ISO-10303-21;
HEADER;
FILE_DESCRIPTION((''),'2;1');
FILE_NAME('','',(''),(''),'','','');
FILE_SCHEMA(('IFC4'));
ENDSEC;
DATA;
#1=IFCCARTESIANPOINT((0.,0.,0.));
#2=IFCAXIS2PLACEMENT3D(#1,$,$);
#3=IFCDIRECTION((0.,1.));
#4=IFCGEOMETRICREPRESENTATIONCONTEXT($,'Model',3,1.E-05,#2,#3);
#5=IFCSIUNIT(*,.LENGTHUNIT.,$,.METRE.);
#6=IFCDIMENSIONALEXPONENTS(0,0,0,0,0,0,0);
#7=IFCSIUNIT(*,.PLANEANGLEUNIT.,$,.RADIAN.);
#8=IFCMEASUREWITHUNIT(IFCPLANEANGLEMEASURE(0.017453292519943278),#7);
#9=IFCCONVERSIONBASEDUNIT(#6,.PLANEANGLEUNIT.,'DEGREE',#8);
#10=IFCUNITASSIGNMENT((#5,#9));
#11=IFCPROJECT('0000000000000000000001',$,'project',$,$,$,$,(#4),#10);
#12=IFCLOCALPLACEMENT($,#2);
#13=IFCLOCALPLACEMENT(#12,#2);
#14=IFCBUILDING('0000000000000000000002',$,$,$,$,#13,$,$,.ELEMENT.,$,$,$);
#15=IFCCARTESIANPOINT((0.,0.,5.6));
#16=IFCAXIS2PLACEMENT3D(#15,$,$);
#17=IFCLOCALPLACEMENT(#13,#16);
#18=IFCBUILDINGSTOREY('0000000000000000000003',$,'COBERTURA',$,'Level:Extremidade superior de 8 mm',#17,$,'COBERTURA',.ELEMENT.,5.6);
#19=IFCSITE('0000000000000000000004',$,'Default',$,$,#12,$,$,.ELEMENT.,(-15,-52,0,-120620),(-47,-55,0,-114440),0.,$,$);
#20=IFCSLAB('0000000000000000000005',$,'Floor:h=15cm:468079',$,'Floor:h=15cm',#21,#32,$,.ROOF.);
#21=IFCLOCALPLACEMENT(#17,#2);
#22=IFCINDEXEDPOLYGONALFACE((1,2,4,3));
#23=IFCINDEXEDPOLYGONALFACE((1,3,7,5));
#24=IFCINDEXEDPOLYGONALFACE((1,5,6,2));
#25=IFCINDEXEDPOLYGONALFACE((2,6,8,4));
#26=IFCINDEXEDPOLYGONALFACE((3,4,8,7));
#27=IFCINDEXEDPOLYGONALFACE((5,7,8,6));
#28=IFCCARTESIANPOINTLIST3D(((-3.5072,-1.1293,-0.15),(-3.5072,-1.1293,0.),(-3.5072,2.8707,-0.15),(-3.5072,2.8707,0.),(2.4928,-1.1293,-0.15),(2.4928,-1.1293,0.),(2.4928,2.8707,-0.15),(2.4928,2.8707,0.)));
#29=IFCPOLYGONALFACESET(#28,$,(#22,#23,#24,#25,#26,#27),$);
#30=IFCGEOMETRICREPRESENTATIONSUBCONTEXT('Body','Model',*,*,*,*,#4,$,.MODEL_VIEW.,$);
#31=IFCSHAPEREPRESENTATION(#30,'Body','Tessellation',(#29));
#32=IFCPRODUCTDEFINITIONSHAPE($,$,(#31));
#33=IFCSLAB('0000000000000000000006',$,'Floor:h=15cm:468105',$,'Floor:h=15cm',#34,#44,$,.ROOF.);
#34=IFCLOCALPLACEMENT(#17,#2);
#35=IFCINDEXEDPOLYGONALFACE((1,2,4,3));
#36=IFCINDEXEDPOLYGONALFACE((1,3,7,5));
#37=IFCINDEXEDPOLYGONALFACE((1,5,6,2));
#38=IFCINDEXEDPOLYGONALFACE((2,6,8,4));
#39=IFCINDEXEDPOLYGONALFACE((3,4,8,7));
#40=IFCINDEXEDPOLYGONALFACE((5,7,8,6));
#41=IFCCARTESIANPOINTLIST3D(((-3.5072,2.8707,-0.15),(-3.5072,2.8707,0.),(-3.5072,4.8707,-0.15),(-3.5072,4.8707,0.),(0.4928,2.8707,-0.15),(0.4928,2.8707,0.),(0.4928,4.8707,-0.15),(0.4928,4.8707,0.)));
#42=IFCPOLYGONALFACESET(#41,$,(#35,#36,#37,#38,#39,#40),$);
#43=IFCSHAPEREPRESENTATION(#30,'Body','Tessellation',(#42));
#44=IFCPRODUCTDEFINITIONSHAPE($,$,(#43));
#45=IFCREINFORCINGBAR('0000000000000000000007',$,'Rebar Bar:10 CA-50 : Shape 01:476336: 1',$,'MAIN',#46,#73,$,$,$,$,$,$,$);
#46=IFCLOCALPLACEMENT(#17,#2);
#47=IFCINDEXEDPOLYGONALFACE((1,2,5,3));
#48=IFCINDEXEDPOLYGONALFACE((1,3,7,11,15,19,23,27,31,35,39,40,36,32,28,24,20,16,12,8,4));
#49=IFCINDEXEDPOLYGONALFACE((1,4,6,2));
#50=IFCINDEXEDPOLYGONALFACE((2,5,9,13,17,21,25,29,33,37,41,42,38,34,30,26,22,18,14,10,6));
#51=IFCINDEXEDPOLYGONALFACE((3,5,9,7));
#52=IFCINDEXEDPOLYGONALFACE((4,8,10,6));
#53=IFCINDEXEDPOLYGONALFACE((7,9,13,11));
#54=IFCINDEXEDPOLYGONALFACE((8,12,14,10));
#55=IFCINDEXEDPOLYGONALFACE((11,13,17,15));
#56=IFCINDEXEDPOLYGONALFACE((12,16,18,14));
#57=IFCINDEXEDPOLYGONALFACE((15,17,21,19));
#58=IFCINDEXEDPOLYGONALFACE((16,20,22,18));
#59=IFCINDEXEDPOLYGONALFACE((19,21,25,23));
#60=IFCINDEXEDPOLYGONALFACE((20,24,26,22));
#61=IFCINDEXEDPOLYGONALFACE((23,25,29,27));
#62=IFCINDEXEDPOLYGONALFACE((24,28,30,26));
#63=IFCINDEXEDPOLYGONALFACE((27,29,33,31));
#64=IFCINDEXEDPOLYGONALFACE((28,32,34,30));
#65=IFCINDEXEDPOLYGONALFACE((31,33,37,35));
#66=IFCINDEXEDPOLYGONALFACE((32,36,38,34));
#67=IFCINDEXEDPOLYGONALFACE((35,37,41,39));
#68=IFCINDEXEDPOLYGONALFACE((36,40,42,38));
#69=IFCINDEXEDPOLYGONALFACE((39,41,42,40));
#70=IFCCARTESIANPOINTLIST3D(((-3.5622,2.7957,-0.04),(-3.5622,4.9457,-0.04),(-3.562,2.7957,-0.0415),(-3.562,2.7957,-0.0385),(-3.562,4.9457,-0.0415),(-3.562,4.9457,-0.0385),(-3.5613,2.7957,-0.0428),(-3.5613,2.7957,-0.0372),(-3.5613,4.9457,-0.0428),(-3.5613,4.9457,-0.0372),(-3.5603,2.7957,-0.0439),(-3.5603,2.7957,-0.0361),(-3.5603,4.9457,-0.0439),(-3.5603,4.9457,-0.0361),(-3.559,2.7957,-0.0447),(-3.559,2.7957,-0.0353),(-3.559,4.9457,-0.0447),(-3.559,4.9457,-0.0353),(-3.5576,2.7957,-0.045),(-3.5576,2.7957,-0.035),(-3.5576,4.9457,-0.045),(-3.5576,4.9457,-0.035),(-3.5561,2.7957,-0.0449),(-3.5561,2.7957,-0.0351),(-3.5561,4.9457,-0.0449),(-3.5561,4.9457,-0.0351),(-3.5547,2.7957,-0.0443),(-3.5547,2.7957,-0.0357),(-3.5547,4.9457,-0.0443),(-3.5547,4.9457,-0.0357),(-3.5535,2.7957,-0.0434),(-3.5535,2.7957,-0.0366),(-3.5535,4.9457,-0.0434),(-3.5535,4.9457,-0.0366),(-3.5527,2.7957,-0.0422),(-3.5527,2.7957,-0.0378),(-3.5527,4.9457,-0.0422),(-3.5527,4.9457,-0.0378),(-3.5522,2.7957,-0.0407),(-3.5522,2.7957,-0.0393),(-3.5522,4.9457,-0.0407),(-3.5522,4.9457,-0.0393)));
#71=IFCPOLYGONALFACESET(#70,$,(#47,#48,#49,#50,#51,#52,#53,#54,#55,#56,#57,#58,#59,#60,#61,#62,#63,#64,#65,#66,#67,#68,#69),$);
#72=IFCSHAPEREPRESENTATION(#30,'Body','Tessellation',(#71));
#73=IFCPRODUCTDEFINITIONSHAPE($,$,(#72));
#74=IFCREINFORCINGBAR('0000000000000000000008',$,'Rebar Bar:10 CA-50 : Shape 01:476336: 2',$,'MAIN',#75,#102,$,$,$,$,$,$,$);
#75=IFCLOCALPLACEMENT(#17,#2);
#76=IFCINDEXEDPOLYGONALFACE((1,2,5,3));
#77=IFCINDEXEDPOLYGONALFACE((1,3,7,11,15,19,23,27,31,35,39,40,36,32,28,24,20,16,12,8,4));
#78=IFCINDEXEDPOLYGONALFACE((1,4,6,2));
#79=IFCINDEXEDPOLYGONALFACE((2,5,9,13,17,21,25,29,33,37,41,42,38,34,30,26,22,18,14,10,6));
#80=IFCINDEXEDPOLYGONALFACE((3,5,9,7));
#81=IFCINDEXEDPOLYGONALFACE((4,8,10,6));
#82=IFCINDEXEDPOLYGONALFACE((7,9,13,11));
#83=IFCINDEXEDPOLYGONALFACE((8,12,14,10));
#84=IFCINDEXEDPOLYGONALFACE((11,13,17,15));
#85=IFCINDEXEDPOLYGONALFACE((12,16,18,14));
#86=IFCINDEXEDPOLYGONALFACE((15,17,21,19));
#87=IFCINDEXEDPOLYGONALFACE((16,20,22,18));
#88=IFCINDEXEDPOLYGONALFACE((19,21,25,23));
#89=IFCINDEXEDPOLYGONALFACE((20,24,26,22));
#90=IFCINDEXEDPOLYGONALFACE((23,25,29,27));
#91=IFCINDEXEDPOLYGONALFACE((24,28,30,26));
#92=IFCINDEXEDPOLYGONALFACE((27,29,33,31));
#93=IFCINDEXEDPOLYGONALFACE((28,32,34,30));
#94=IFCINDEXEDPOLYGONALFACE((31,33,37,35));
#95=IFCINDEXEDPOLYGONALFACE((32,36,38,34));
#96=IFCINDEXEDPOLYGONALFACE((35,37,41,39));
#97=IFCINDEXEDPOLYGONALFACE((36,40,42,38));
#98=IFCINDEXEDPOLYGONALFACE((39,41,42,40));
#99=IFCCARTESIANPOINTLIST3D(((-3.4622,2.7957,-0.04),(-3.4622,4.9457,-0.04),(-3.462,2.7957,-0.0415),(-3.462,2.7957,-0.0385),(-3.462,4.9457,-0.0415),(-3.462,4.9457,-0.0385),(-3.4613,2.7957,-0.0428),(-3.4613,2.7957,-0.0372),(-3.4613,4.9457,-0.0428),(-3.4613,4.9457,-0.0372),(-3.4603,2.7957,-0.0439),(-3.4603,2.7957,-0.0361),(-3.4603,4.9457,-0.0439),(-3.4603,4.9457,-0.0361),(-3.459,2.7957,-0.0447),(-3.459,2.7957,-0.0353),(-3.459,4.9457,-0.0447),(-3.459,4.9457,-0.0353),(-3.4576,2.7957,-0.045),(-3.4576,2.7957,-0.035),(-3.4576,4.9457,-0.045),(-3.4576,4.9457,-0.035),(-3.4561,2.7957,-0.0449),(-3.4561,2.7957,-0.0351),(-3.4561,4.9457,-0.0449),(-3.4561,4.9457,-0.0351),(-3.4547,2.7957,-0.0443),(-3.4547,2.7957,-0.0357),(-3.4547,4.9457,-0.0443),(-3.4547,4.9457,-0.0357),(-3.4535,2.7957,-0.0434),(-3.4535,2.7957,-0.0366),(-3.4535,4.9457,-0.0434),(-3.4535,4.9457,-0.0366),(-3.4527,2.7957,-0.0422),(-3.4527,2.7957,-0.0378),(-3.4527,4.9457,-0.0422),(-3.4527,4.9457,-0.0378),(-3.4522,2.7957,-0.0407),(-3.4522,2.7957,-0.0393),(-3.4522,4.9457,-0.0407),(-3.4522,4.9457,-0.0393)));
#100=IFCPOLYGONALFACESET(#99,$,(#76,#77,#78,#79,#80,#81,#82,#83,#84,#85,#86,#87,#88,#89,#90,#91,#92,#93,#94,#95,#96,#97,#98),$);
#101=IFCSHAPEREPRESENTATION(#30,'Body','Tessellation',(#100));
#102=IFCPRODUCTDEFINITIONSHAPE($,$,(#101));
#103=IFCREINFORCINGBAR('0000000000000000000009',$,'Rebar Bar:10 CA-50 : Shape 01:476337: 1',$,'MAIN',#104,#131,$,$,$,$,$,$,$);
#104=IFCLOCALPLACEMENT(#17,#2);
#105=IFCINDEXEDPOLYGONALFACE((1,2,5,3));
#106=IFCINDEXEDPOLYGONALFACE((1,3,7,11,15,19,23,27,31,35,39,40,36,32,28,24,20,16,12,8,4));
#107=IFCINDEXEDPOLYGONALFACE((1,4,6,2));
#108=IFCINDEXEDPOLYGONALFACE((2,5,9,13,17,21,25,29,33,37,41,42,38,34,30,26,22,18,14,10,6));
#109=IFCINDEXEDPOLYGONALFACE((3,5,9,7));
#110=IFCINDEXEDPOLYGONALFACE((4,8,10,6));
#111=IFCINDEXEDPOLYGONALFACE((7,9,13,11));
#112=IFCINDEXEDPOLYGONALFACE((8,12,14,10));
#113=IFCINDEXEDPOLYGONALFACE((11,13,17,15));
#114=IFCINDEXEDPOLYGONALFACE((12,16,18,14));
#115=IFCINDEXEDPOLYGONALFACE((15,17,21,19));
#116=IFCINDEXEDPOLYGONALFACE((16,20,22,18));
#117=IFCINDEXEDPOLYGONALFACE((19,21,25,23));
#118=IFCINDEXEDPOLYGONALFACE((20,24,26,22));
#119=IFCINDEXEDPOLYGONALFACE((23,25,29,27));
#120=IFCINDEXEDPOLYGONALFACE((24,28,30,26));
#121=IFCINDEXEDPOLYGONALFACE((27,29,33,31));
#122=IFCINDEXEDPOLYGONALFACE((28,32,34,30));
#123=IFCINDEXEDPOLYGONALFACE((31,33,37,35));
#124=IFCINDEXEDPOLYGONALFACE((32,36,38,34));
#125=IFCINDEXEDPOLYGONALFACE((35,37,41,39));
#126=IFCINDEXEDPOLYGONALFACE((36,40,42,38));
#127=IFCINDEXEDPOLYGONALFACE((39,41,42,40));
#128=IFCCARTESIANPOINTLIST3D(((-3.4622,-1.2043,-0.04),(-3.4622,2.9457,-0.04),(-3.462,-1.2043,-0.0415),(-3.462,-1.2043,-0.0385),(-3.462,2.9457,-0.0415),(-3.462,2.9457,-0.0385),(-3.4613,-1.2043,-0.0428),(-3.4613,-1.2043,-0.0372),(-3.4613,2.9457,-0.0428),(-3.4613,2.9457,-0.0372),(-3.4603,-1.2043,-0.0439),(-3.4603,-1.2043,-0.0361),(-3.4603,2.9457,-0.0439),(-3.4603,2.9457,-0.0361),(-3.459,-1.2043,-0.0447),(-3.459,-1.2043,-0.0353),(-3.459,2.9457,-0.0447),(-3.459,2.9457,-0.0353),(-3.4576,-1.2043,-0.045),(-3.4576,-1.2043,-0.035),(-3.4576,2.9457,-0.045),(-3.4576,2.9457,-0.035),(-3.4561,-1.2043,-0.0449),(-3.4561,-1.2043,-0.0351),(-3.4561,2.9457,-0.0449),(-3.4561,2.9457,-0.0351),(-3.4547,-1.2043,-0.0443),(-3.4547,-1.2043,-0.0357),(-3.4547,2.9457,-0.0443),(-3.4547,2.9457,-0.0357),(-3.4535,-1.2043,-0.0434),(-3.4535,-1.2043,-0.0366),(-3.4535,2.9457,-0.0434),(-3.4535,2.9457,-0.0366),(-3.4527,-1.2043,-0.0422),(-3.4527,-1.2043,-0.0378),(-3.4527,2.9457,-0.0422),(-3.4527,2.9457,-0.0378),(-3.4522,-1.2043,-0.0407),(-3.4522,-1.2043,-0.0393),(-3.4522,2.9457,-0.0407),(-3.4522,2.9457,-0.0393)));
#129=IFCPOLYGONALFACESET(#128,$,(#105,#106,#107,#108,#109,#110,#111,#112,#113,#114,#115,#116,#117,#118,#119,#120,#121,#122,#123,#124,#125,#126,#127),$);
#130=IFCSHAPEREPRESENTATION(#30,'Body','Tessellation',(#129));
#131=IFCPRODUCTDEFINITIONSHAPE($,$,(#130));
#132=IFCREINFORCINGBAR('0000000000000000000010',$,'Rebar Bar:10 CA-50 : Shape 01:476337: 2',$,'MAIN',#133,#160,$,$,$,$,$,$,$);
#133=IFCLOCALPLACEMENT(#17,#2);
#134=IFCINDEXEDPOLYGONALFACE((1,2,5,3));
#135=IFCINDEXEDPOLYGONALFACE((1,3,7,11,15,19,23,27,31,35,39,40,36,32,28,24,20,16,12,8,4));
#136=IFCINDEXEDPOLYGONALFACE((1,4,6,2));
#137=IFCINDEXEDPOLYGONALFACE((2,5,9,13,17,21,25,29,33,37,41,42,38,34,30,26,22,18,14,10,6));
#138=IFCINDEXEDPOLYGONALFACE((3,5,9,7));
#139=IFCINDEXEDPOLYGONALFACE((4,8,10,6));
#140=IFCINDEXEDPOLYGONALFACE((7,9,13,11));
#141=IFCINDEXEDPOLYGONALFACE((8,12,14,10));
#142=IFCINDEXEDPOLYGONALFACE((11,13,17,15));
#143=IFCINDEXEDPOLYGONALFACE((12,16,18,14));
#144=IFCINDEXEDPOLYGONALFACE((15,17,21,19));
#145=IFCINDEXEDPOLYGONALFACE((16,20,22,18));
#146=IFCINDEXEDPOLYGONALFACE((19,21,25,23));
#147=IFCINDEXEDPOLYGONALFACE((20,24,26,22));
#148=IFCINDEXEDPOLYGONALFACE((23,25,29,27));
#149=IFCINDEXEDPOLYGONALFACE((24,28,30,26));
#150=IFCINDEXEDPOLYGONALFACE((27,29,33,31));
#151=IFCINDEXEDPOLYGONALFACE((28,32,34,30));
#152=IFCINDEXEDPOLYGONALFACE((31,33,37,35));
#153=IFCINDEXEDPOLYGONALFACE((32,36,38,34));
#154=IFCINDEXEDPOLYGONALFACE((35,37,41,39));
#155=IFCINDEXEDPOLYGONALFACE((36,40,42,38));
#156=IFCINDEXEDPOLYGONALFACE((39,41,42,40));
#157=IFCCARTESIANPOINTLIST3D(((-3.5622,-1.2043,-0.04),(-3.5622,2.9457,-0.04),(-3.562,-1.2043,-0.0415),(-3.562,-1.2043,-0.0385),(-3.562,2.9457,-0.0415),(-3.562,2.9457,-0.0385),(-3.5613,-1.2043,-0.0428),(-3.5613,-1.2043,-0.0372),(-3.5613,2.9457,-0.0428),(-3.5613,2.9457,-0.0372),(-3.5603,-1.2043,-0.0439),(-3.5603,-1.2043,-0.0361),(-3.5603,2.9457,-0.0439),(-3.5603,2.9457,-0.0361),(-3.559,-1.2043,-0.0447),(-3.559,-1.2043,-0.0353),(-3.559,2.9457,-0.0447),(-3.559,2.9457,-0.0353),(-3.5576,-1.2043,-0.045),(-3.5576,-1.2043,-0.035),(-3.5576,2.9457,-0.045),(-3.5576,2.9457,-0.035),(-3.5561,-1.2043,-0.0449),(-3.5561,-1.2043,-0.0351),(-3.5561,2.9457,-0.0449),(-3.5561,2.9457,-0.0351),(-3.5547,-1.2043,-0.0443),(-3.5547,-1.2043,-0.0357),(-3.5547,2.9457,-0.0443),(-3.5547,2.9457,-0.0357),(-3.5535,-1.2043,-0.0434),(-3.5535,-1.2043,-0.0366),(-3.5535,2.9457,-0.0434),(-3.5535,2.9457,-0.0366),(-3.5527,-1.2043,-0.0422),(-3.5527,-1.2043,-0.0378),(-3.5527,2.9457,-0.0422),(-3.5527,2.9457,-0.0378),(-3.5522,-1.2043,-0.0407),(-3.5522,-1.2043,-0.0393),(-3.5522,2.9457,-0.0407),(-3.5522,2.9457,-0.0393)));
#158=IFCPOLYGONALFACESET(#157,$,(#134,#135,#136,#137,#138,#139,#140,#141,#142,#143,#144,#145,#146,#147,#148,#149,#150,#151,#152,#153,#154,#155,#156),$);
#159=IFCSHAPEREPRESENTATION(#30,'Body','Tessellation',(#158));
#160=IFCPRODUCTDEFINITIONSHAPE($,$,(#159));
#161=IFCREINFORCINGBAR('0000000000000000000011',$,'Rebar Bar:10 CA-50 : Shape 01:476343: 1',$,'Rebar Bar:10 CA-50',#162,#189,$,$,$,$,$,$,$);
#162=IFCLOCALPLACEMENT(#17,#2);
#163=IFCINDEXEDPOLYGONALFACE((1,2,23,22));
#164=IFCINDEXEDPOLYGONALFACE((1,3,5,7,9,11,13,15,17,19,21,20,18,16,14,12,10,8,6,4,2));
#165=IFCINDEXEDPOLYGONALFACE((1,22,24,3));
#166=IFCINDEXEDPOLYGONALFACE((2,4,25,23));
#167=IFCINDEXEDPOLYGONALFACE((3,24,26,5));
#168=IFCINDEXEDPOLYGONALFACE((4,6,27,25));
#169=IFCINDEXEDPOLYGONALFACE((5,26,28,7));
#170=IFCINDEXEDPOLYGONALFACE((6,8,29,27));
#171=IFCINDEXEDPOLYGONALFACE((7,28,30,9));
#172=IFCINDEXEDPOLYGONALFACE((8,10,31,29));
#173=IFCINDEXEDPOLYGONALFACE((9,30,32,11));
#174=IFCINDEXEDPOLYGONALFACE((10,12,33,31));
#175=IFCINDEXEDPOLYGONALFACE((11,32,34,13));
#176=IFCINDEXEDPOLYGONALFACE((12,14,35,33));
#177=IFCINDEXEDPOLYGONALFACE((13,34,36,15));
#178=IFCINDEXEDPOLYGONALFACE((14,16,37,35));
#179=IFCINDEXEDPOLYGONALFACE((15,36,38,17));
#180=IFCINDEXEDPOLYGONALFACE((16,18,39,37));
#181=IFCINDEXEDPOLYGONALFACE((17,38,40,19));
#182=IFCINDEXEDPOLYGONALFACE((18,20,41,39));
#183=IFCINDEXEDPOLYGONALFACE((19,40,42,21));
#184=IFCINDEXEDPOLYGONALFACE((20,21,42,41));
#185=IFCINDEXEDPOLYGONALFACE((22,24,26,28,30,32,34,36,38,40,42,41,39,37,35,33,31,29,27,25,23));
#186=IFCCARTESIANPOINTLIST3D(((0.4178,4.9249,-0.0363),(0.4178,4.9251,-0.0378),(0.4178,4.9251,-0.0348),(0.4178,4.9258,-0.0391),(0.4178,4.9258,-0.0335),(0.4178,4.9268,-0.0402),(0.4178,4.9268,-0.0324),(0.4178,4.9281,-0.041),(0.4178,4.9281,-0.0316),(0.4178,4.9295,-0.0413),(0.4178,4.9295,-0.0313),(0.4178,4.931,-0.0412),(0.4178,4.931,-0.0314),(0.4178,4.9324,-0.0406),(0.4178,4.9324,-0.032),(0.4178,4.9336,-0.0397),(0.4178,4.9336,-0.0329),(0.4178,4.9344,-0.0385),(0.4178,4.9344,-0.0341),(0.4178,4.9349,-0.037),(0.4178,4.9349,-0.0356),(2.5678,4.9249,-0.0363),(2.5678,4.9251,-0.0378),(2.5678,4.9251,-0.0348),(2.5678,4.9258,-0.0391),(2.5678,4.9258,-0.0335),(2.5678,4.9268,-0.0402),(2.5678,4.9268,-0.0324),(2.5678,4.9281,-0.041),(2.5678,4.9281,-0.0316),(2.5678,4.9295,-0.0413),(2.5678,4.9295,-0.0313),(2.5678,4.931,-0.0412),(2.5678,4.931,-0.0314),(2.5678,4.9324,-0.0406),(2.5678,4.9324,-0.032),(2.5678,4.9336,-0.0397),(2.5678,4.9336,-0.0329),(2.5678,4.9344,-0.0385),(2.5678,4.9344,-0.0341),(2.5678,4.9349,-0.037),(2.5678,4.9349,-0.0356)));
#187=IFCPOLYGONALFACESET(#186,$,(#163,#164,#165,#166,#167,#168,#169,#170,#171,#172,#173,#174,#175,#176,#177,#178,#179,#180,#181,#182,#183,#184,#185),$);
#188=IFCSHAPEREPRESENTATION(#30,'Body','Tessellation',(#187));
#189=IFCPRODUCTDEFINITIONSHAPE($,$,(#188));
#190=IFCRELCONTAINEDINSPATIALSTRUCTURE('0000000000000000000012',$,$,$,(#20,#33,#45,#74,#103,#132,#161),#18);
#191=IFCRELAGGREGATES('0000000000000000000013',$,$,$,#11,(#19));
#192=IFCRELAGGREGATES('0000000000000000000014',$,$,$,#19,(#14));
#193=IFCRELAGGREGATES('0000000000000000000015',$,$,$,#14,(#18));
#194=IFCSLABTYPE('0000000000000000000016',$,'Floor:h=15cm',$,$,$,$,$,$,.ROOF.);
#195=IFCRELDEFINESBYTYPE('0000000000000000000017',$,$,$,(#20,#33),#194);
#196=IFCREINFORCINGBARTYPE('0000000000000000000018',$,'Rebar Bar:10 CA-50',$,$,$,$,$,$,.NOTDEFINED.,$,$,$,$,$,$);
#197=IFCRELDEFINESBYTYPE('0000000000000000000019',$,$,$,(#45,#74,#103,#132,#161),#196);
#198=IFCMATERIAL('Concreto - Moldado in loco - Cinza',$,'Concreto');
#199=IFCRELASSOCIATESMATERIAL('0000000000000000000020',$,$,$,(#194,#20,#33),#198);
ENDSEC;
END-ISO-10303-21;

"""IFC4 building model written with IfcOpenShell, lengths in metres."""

from ifc_helpers import new_model, entity, si_unit, converted_unit, direction, frame, origin, place, context, subcontext, project, spatial, indexed_curve, outline, extrude, material, type_object, element, save


model = new_model("IFC4")

# Units and contexts
model_context = context("Model", 3, precision=1e-05, world=origin(), true_north=direction((0.0, 1.0)))
body_context = subcontext(model_context, "Body", "Model", "MODEL_VIEW")
ifc_project = project(units=[si_unit("LENGTHUNIT", "METRE"), converted_unit("PLANEANGLEUNIT", "DEGREE", entity("IfcPlaneAngleMeasure", 0.017453292519943278), si_unit("PLANEANGLEUNIT", "RADIAN"), dimensions=[0, 0, 0, 0, 0, 0, 0])], contexts=[model_context])

# Site, building, storey
site_placement = place(None, origin())
site = spatial("IfcSite", under=ifc_project, at=site_placement, Name="Default", CompositionType="ELEMENT", RefLatitude=(-15, -52, 0, -120620), RefLongitude=(-47, -55, 0, -114440), RefElevation=0.0)
building_placement = place(site_placement, origin())
building = spatial("IfcBuilding", under=site, at=building_placement, CompositionType="ELEMENT")
storey_placement = place(building_placement, frame((0.0, 0.0, 5.6)))
storey = spatial("IfcBuildingStorey", under=building, at=storey_placement, Name="COBERTURA", ObjectType="Level:Extremidade superior de 8 mm", LongName="COBERTURA", CompositionType="ELEMENT", Elevation=5.6)

# Shared definitions
ifc_material = material(Name="Concreto - Moldado in loco - Cinza", Category="Concreto")

# Slabs
slab_type = type_object("IfcSlabType", Name="Floor:h=15cm", PredefinedType="ROOF", material=ifc_material)
slab_1_placement = place(storey_placement, origin())
element("IfcSlab", 1, at=slab_1_placement, inside=storey, type_object=slab_type, material=ifc_material, Name="Floor:h=15cm:468079", ObjectType="Floor:h=15cm", PredefinedType="ROOF", context=body_context, shape_type="SweptSolid", body=[
    extrude(outline(indexed_curve([(-2.0, -3.0), (2.0, -3.0), (2.0, 3.0), (-2.0, 3.0), (-2.0, -3.0)], self_intersect=False)), frame((-0.5072, 0.8707, 0.0), z_axis=(0.0, 0.0, -1.0), x_axis=(0.0, 1.0, 0.0)), (0.0, 0.0, 1.0), 0.15),
])
slab_2_placement = place(storey_placement, origin())
element("IfcSlab", 2, at=slab_2_placement, inside=storey, type_object=slab_type, material=ifc_material, Name="Floor:h=15cm:468105", ObjectType="Floor:h=15cm", PredefinedType="ROOF", context=body_context, shape_type="SweptSolid", body=[
    extrude(outline(indexed_curve([(-1.0, -2.0), (1.0, -2.0), (1.0, 2.0), (-1.0, 2.0), (-1.0, -2.0)], self_intersect=False)), frame((-1.5072, 3.8707, 0.0), z_axis=(0.0, 0.0, -1.0), x_axis=(0.0, 1.0, 0.0)), (0.0, 0.0, 1.0), 0.15),
])

# Reinforcing bars
reinforcing_bar_type = type_object("IfcReinforcingBarType", Name="Rebar Bar:10 CA-50", PredefinedType="NOTDEFINED")
reinforcing_bar_1_placement = place(storey_placement, origin())
element("IfcReinforcingBar", 3, at=reinforcing_bar_1_placement, inside=storey, type_object=reinforcing_bar_type, Name="Rebar Bar:10 CA-50 : Shape 01:476336: 1", ObjectType="MAIN", context=body_context, shape_type="AdvancedSweptSolid", body=[
    entity("IfcSweptDiskSolid", entity("IfcIndexedPolyCurve", entity("IfcCartesianPointList3D", [[-3.5572, 4.9457, -0.04], [-3.5572, 2.7957, -0.04]]), None, False), 0.005, None, 0.0, 1.0),
])
reinforcing_bar_2_placement = place(storey_placement, origin())
element("IfcReinforcingBar", 4, at=reinforcing_bar_2_placement, inside=storey, type_object=reinforcing_bar_type, Name="Rebar Bar:10 CA-50 : Shape 01:476336: 2", ObjectType="MAIN", context=body_context, shape_type="AdvancedSweptSolid", body=[
    entity("IfcSweptDiskSolid", entity("IfcIndexedPolyCurve", entity("IfcCartesianPointList3D", [[-3.4572, 4.9457, -0.04], [-3.4572, 2.7957, -0.04]]), None, False), 0.005, None, 0.0, 1.0),
])
reinforcing_bar_3_placement = place(storey_placement, origin())
element("IfcReinforcingBar", 5, at=reinforcing_bar_3_placement, inside=storey, type_object=reinforcing_bar_type, Name="Rebar Bar:10 CA-50 : Shape 01:476337: 1", ObjectType="MAIN", context=body_context, shape_type="AdvancedSweptSolid", body=[
    entity("IfcSweptDiskSolid", entity("IfcIndexedPolyCurve", entity("IfcCartesianPointList3D", [[-3.4572, 2.9457, -0.04], [-3.4572, -1.2043, -0.04]]), None, False), 0.005, None, 0.0, 1.0),
])
reinforcing_bar_4_placement = place(storey_placement, origin())
element("IfcReinforcingBar", 6, at=reinforcing_bar_4_placement, inside=storey, type_object=reinforcing_bar_type, Name="Rebar Bar:10 CA-50 : Shape 01:476337: 2", ObjectType="MAIN", context=body_context, shape_type="AdvancedSweptSolid", body=[
    entity("IfcSweptDiskSolid", entity("IfcIndexedPolyCurve", entity("IfcCartesianPointList3D", [[-3.5572, 2.9457, -0.04], [-3.5572, -1.2043, -0.04]]), None, False), 0.005, None, 0.0, 1.0),
])
reinforcing_bar_5_placement = place(storey_placement, origin())
element("IfcReinforcingBar", 7, at=reinforcing_bar_5_placement, inside=storey, type_object=reinforcing_bar_type, Name="Rebar Bar:10 CA-50 : Shape 01:476343: 1", ObjectType="Rebar Bar:10 CA-50", context=body_context, shape_type="AdvancedSweptSolid", body=[
    entity("IfcSweptDiskSolid", entity("IfcIndexedPolyCurve", entity("IfcCartesianPointList3D", [[2.5678, 4.9299, -0.0363], [0.4178, 4.9299, -0.0363]]), None, False), 0.005, None, 0.0, 1.0),
])

save(model, "model.ifc")
